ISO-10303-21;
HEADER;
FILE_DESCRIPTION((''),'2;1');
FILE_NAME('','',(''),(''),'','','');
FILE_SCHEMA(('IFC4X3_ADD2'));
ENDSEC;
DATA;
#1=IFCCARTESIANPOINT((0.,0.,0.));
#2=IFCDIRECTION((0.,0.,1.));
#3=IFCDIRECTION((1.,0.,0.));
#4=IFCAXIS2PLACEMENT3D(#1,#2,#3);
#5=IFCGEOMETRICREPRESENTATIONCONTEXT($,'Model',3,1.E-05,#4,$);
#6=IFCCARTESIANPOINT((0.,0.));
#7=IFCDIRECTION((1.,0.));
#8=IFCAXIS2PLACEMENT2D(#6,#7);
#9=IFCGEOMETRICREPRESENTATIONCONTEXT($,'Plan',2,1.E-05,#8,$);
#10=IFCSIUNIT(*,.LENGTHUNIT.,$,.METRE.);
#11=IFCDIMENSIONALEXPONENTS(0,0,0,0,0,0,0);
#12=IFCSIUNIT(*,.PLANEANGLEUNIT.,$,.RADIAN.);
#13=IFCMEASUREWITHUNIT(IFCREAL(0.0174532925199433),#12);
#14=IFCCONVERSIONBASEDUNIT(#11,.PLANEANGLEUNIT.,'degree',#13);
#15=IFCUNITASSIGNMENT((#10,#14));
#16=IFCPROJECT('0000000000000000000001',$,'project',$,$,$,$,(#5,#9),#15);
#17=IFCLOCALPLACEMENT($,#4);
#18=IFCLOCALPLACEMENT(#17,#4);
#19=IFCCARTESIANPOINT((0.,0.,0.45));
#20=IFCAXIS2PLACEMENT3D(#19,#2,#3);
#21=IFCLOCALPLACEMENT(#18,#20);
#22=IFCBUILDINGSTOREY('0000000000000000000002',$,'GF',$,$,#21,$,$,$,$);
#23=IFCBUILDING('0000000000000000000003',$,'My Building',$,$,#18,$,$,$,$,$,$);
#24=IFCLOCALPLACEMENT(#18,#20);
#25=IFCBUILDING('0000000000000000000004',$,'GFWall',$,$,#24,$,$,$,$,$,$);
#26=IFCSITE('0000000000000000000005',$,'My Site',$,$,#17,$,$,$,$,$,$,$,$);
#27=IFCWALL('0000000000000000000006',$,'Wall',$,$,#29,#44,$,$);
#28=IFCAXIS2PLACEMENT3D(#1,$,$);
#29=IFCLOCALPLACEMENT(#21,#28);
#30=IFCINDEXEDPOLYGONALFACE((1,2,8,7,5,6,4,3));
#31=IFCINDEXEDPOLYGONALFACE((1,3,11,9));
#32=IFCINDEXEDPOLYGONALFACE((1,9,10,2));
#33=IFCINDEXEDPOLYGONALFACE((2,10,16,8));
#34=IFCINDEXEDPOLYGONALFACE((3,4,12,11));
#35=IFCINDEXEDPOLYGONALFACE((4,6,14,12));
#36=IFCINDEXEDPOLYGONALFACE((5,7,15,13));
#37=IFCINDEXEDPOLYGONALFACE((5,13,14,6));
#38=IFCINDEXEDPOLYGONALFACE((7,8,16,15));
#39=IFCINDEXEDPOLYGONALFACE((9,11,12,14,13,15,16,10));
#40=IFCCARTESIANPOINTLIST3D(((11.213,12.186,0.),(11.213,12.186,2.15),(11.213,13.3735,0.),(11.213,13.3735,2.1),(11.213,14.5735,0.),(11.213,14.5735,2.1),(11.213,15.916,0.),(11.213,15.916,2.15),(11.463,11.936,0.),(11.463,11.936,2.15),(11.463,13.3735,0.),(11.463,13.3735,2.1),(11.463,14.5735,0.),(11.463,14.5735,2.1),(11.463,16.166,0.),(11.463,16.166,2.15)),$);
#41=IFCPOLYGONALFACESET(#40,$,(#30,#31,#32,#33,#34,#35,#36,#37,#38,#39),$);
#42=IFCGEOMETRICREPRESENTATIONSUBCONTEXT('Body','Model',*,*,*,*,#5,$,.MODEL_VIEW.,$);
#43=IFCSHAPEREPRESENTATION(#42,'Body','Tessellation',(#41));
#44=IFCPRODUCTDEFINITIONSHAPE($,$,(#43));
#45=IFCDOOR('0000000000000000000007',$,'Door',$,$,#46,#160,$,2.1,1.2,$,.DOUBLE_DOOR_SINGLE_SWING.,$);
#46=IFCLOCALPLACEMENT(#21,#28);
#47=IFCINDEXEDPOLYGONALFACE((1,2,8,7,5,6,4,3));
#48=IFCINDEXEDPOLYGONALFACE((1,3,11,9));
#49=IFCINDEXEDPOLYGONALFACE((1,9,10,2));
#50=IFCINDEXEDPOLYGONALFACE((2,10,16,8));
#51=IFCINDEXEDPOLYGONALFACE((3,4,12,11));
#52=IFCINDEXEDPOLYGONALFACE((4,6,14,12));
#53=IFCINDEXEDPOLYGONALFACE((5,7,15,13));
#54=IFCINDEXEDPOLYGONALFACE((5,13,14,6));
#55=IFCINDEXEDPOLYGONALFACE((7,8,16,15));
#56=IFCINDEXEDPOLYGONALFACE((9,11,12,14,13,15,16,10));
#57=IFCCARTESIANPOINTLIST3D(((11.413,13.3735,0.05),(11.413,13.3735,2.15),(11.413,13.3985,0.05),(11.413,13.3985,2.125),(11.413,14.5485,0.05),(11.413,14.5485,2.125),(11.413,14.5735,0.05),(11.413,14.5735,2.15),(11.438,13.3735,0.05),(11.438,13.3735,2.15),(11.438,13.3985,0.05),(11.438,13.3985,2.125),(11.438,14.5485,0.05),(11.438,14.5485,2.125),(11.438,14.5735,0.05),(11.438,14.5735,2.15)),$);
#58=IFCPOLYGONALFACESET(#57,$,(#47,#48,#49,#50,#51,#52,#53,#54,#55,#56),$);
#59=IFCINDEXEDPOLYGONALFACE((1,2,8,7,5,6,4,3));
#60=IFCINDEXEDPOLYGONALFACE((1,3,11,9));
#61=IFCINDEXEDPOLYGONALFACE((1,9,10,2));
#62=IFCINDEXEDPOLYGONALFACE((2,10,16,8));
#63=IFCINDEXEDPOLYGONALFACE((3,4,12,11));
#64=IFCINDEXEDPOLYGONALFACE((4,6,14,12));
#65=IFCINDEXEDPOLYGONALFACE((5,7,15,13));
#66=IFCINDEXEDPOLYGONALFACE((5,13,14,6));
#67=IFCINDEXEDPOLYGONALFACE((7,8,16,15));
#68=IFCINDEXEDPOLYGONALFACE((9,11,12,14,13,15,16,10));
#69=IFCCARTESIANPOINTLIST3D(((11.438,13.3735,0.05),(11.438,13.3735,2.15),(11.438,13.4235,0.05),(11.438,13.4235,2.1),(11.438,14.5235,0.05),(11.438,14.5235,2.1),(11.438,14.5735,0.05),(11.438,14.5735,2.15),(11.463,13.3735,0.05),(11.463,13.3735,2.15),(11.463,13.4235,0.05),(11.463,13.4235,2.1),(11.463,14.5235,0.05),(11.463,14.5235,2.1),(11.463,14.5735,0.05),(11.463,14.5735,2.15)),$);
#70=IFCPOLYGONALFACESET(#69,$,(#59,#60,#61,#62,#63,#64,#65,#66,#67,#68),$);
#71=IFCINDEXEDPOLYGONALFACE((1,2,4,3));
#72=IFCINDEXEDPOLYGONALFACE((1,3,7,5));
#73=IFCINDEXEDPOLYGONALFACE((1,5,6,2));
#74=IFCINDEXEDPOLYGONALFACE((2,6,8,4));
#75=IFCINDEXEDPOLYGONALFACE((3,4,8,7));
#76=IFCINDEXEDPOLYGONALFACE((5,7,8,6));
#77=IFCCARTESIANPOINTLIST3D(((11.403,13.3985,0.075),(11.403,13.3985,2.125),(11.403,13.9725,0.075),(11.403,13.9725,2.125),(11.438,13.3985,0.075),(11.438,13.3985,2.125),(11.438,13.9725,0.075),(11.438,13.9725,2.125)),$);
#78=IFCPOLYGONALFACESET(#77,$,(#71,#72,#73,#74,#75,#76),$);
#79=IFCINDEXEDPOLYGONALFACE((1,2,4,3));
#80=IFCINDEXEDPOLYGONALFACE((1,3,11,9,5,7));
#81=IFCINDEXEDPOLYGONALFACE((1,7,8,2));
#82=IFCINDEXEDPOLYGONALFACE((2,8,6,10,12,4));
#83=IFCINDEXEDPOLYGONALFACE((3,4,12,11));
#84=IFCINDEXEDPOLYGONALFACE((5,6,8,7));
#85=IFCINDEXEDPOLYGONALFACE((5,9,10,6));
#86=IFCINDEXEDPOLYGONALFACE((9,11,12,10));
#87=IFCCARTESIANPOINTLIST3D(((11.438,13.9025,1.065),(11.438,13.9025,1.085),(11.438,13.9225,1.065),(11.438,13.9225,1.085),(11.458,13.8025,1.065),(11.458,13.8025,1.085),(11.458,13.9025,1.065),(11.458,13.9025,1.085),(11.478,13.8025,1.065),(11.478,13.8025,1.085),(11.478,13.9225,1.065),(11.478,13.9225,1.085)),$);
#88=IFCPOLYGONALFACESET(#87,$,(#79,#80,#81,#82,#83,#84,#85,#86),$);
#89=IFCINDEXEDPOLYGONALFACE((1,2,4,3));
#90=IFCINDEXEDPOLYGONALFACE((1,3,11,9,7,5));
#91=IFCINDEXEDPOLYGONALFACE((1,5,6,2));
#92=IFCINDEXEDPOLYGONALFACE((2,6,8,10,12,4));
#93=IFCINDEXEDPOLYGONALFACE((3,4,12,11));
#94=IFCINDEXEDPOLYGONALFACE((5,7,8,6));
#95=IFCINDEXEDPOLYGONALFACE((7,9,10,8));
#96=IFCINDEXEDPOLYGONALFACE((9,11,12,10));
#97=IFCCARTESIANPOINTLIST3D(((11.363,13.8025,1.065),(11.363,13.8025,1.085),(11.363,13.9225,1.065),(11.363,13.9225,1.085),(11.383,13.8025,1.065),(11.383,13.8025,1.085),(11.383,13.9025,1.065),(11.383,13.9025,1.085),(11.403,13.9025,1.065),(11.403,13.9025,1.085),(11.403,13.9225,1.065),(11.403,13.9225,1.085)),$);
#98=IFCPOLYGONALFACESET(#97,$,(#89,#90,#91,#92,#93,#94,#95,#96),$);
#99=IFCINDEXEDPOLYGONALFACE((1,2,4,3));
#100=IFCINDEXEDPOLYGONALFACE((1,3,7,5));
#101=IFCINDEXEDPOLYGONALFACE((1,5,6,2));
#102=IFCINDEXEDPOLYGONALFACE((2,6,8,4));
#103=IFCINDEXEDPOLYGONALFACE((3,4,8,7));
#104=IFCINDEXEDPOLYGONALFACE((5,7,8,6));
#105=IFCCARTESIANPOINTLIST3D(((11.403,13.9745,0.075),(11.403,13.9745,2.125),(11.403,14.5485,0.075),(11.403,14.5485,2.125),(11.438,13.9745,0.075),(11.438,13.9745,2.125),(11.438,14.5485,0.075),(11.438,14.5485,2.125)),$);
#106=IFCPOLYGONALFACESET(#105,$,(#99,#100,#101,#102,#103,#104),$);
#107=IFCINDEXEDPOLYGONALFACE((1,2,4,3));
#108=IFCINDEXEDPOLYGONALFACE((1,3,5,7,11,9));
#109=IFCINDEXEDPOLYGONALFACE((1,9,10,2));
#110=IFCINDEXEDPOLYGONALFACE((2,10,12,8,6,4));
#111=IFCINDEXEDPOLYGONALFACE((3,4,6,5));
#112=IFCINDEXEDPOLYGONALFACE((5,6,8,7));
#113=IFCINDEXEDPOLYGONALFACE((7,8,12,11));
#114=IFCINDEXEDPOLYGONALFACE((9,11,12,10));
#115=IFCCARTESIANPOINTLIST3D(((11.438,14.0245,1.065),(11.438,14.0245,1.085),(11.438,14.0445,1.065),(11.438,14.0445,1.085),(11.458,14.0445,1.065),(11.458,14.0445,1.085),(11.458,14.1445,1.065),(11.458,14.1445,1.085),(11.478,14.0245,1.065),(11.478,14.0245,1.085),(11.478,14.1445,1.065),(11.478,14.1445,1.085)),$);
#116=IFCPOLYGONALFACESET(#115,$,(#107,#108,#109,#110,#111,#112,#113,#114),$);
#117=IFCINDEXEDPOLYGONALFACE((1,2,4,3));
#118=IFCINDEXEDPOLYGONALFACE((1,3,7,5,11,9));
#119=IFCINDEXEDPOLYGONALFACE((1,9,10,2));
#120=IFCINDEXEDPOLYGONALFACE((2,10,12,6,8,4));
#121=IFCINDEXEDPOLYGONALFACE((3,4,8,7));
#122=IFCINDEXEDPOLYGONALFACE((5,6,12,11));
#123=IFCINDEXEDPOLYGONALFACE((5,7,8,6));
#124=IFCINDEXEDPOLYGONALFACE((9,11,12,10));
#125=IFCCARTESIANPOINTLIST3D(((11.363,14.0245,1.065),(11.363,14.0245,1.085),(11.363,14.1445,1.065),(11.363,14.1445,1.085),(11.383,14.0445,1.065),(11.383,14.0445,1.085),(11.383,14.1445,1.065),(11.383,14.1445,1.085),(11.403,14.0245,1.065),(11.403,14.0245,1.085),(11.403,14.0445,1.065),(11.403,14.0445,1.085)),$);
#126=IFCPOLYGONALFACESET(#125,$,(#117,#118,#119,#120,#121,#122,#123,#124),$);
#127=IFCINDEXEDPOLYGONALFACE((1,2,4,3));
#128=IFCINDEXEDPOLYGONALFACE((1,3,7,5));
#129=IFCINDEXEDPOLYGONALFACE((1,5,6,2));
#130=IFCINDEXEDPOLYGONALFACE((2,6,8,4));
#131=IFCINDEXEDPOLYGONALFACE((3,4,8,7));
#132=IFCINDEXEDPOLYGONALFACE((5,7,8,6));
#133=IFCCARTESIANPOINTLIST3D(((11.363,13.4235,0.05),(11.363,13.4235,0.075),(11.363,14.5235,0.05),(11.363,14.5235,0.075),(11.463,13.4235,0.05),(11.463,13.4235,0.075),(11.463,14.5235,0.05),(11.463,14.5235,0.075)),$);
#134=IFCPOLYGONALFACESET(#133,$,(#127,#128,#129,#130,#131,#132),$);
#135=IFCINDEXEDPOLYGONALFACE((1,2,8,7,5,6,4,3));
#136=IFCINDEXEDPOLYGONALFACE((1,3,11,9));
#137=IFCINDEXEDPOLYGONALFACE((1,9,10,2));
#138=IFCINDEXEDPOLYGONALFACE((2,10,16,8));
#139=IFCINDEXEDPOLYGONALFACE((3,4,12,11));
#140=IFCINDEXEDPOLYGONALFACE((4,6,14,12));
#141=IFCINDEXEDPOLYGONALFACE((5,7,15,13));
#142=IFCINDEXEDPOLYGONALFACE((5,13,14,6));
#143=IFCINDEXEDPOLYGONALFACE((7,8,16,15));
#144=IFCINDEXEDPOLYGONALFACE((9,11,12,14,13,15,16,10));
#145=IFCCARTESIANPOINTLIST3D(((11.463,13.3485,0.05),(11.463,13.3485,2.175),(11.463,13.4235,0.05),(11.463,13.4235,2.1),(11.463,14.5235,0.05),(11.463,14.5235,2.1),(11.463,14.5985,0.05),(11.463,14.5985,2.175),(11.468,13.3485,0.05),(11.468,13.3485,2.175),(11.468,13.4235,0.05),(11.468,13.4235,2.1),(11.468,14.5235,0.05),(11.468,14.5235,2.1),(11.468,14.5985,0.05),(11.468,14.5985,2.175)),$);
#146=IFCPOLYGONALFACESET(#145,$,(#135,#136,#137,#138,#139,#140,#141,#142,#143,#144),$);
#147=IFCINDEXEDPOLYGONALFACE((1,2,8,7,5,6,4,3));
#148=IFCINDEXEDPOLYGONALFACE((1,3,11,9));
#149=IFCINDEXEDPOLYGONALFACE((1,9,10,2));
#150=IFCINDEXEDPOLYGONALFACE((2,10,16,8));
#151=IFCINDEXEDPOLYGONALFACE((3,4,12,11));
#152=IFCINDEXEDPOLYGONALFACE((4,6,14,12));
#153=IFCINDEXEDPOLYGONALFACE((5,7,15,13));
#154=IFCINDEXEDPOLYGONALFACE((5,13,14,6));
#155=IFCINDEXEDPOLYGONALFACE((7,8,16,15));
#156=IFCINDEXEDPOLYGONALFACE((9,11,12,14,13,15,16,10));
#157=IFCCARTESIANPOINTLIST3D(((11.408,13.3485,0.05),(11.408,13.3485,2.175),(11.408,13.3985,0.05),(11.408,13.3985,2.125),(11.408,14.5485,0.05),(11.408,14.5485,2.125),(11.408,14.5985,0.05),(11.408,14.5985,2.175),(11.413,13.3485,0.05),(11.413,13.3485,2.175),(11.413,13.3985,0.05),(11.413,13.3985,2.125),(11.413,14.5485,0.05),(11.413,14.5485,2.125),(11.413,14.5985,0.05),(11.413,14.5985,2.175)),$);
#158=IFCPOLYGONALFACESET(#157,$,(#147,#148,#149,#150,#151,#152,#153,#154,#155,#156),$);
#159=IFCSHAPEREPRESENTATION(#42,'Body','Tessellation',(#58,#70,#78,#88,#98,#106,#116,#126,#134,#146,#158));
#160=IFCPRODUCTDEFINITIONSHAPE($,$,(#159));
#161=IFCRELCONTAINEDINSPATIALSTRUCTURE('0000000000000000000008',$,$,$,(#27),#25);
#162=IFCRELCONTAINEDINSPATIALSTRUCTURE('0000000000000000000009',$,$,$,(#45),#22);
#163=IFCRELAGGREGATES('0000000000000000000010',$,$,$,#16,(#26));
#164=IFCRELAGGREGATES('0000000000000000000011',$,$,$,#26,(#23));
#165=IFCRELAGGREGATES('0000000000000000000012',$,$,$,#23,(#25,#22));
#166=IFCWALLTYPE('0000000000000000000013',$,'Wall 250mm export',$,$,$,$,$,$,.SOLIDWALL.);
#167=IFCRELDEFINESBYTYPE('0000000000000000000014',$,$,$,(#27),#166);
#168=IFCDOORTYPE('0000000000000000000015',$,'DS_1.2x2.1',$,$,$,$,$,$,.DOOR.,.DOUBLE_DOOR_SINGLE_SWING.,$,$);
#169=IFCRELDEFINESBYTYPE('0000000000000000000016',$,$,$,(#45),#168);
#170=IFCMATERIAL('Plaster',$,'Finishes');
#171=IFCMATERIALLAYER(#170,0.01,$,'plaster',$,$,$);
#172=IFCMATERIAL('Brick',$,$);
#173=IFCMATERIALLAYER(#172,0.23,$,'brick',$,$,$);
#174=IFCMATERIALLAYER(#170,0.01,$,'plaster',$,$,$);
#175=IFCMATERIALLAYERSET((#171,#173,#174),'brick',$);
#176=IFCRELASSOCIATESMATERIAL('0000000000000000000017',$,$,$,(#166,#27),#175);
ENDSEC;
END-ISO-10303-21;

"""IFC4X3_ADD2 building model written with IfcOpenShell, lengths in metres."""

from ifc_helpers import new_model, entity, si_unit, converted_unit, frame, origin_with_axes, origin_2d_with_axis, place, context, subcontext, project, spatial, line, indexed_curve, outline, extrude, shape, source, transform, mapped, material, layer, layer_set, layer_usage, type_object, type_shapes, element, fill, save


model = new_model("IFC4X3_ADD2")

# Units and contexts
model_context = context("Model", 3, precision=1e-05, world=origin_with_axes())
plan_context = context("Plan", 2, precision=1e-05, world=origin_2d_with_axis())
body_context_1 = subcontext(model_context, "Body", "Model", "MODEL_VIEW")
body_context_2 = subcontext(plan_context, "Body", "Plan", "PLAN_VIEW")
ifc_project = project(units=[si_unit("LENGTHUNIT", "METRE"), converted_unit("PLANEANGLEUNIT", "degree", entity("IfcReal", 0.0174532925199433), si_unit("PLANEANGLEUNIT", "RADIAN"), dimensions=[0, 0, 0, 0, 0, 0, 0])], contexts=[model_context, plan_context])

# Site, buildings
site_placement = place(None, origin_with_axes())
site = spatial("IfcSite", under=ifc_project, at=site_placement, Name="My Site")
building_1_placement = place(site_placement, origin_with_axes())
building_1 = spatial("IfcBuilding", under=site, at=building_1_placement, Name="My Building")
building_2_placement = place(building_1_placement, frame((0.0, 0.0, 0.45), z_axis=(0.0, 0.0, 1.0), x_axis=(1.0, 0.0, 0.0)))
building_2 = spatial("IfcBuilding", under=building_1, at=building_2_placement, Name="GFWall")

# Shared definitions
ifc_material_1 = material(Name="Plaster", Category="Finishes")

# Shared definitions
storey_placement = place(building_1_placement, frame((0.0, 0.0, 0.45), z_axis=(0.0, 0.0, 1.0), x_axis=(1.0, 0.0, 0.0)))
storey = spatial("IfcBuildingStorey", under=building_1, at=storey_placement, Name="GF")

# Shared definitions
ifc_layer_1 = layer(ifc_material_1, 0.01, Name="plaster")
ifc_material_2 = material(Name="Brick")
ifc_layer_2 = layer(ifc_material_2, 0.23, Name="brick")
ifc_layer_3 = layer(ifc_material_1, 0.01, Name="plaster")
ifc_layer_set_1 = layer_set([ifc_layer_1, ifc_layer_2, ifc_layer_3], Name="brick")
wall_type_1 = type_object("IfcWallType", Name="Wall 250mm export", PredefinedType="SOLIDWALL", material=ifc_layer_set_1)

# Wall, opening, door
ifc_layer_usage_1 = layer_usage(ifc_layer_set_1, "AXIS2", "POSITIVE", 0.0)
wall_1_placement = place(building_2_placement, frame((11.463, 11.936, 0.0), z_axis=(0.0, 0.0, 1.0), x_axis=(0.0, 1.0, 0.0)))
wall_1 = element("IfcWall", 1, at=wall_1_placement, inside=building_2, type_object=wall_type_1, material=ifc_layer_usage_1, Name="Wall", context=body_context_1, shape_type="SweptSolid", body=[
    extrude(outline(indexed_curve([(0.0, 0.0), (0.25, 0.25), (3.98, 0.25), (4.23, 0.0)], segments=[line(1, 2, 3, 4, 1)])), origin_with_axes(), (0.0, 0.0, 1.0), 2.15),
])
shared_shape_1 = source(origin_with_axes(), body_context_1, "Body", "SweptSolid", [
    extrude(outline(indexed_curve([(0.0, 0.0), (1.2, 0.0), (1.2, 2.1), (0.0, 2.1)], segments=[line(1, 2, 3, 4, 1)])), frame((0.0, -0.6, 0.0), z_axis=(0.0, -1.0, 0.0), x_axis=(1.0, 0.0, 0.0)), (0.0, 0.0, -1.0), 1.2),
])
opening_1_placement = place(wall_1_placement, frame((1.4375, 0.0, 0.0), z_axis=(0.0, 0.0, 1.0), x_axis=(1.0, 0.0, 0.0)))
opening_1 = element("IfcOpeningElement", 2, at=opening_1_placement, cuts=wall_1, PredefinedType="OPENING", context=body_context_1, shape_type="MappedRepresentation", body=[
    mapped(shared_shape_1, transform((0.0, 0.0, 0.0), x_axis=(1.0, 0.0, 0.0), y_axis=(0.0, 1.0, 0.0), z_axis=(0.0, 0.0, 1.0), scale=1.0)),
])
door_type_1 = type_object("IfcDoorType", Name="DS_1.2x2.1", OperationType="DOUBLE_DOOR_SINGLE_SWING", PredefinedType="DOOR")
shared_shape_2 = source(origin_with_axes(), body_context_1, "Body", "SweptSolid", [
    extrude(outline(indexed_curve([(0.0, 0.0), (0.0, 2.1), (1.2, 2.1), (1.2, 0.0), (1.175, 0.0), (1.175, 2.075), (0.025, 2.075), (0.025, 0.0)], segments=[line(1, 2, 3, 4, 5, 6, 7, 8, 1)])), frame((0.0, 0.025, 0.0), z_axis=(0.0, -1.0, 0.0), x_axis=(1.0, 0.0, 0.0)), (0.0, 0.0, -1.0), 0.025),
    extrude(outline(indexed_curve([(0.0, 0.0), (0.0, 2.1), (1.2, 2.1), (1.2, 0.0), (1.15, 0.0), (1.15, 2.05), (0.05, 2.05), (0.05, 0.0)], segments=[line(1, 2, 3, 4, 5, 6, 7, 8, 1)])), frame((0.0, 0.0, 0.0), z_axis=(0.0, -1.0, 0.0), x_axis=(1.0, 0.0, 0.0)), (0.0, 0.0, -1.0), 0.025),
    extrude(outline(indexed_curve([(0.0, 0.0), (0.574, 0.0), (0.574, 0.035), (0.0, 0.035)], segments=[line(1, 2, 3, 4, 1)])), frame((0.025, 0.025, 0.025), z_axis=(0.0, 0.0, 1.0), x_axis=(1.0, 0.0, 0.0)), (0.0, 0.0, 1.0), 2.05),
    extrude(outline(indexed_curve([(0.0, 0.0), (0.0, -0.04), (-0.12, -0.04), (-0.12, -0.02), (-0.02, -0.02), (-0.02, 0.0)], segments=[line(1, 2, 3, 4, 5, 6, 1)])), frame((0.549, 0.025, 1.015), z_axis=(0.0, 0.0, 1.0), x_axis=(1.0, 0.0, 0.0)), (0.0, 0.0, 1.0), 0.02),
    extrude(outline(indexed_curve([(0.0, 0.0), (0.0, 0.04), (-0.12, 0.04), (-0.12, 0.02), (-0.02, 0.02), (-0.02, 0.0)], segments=[line(1, 2, 3, 4, 5, 6, 1)])), frame((0.549, 0.06, 1.015), z_axis=(0.0, 0.0, 1.0), x_axis=(1.0, 0.0, 0.0)), (0.0, 0.0, 1.0), 0.02),
    extrude(outline(indexed_curve([(0.0, 0.0), (-0.574, 0.0), (-0.574, 0.035), (0.0, 0.035)], segments=[line(1, 2, 3, 4, 1)])), frame((1.175, 0.025, 0.025), z_axis=(0.0, 0.0, 1.0), x_axis=(1.0, 0.0, 0.0)), (0.0, 0.0, 1.0), 2.05),
    extrude(outline(indexed_curve([(0.0, 0.0), (0.0, -0.04), (0.12, -0.04), (0.12, -0.02), (0.02, -0.02), (0.02, 0.0)], segments=[line(1, 2, 3, 4, 5, 6, 1)])), frame((0.651, 0.025, 1.015), z_axis=(0.0, 0.0, 1.0), x_axis=(1.0, 0.0, 0.0)), (0.0, 0.0, 1.0), 0.02),
    extrude(outline(indexed_curve([(0.0, 0.0), (0.0, 0.04), (0.12, 0.04), (0.12, 0.02), (0.02, 0.02), (0.02, 0.0)], segments=[line(1, 2, 3, 4, 5, 6, 1)])), frame((0.651, 0.06, 1.015), z_axis=(0.0, 0.0, 1.0), x_axis=(1.0, 0.0, 0.0)), (0.0, 0.0, 1.0), 0.02),
    extrude(outline(indexed_curve([(0.0, 0.0), (1.1, 0.0), (1.1, 0.1), (0.0, 0.1)], segments=[line(1, 2, 3, 4, 1)])), frame((0.05, 0.0, 0.0), z_axis=(0.0, 0.0, 1.0), x_axis=(1.0, 0.0, 0.0)), (0.0, 0.0, 1.0), 0.025),
    extrude(outline(indexed_curve([(0.0, 0.0), (0.0, 2.125), (1.25, 2.125), (1.25, 0.0), (1.175, 0.0), (1.175, 2.05), (0.075, 2.05), (0.075, 0.0)], segments=[line(1, 2, 3, 4, 5, 6, 7, 8, 1)])), frame((-0.025, -0.005, 0.0), z_axis=(0.0, -1.0, 0.0), x_axis=(1.0, 0.0, 0.0)), (0.0, 0.0, -1.0), 0.005),
    extrude(outline(indexed_curve([(0.0, 0.0), (0.0, 2.125), (1.25, 2.125), (1.25, 0.0), (1.2, 0.0), (1.2, 2.075), (0.05, 2.075), (0.05, 0.0)], segments=[line(1, 2, 3, 4, 5, 6, 7, 8, 1)])), frame((-0.025, 0.05, 0.0), z_axis=(0.0, -1.0, 0.0), x_axis=(1.0, 0.0, 0.0)), (0.0, 0.0, -1.0), 0.005),
])
shared_shape_3 = source(origin_with_axes(), body_context_2, "Body", "Curve2D", [
    entity("IfcIndexedPolyCurve", entity("IfcCartesianPointList2D", [[0.0, 0.0], [0.0, 0.05], [0.025, 0.05], [0.025, 0.025], [0.05, 0.025], [0.05, 0.0]]), [entity("IfcLineIndex", [1, 2, 3, 4, 5, 6, 1])]),
    entity("IfcIndexedPolyCurve", entity("IfcCartesianPointList2D", [[1.2, 0.0], [1.2, 0.05], [1.175, 0.05], [1.175, 0.025], [1.15, 0.025], [1.15, 0.0]]), [entity("IfcLineIndex", [1, 2, 3, 4, 5, 6, 1])]),
    entity("IfcTrimmedCurve", entity("IfcEllipse", entity("IfcAxis2Placement2D", entity("IfcCartesianPoint", [0.06, 0.05]), entity("IfcDirection", [1.0, 0.0])), 0.54, 0.575), [entity("IfcCartesianPoint", [0.6, 0.05])], [entity("IfcCartesianPoint", [0.06, 0.625])], True, "CARTESIAN"),
    entity("IfcIndexedPolyCurve", entity("IfcCartesianPointList2D", [[0.025, 0.05], [0.06, 0.05], [0.06, 0.625], [0.025, 0.625]]), [entity("IfcLineIndex", [1, 2, 3, 4, 1])]),
    entity("IfcTrimmedCurve", entity("IfcEllipse", entity("IfcAxis2Placement2D", entity("IfcCartesianPoint", [1.14, 0.05]), entity("IfcDirection", [1.0, 0.0])), 0.54, 0.575), [entity("IfcCartesianPoint", [1.14, 0.625])], [entity("IfcCartesianPoint", [0.6, 0.05])], True, "CARTESIAN"),
    entity("IfcIndexedPolyCurve", entity("IfcCartesianPointList2D", [[1.175, 0.05], [1.14, 0.05], [1.14, 0.625], [1.175, 0.625]]), [entity("IfcLineIndex", [1, 2, 3, 4, 1])]),
])
type_shapes(door_type_1, [shared_shape_2, shared_shape_3])
door_1_placement = place(opening_1_placement, frame((0.0, 0.0, 0.05), z_axis=(0.0, 0.0, 1.0), x_axis=(1.0, 0.0, 0.0)))
door_1 = element("IfcDoor", 3, at=door_1_placement, inside=storey, type_object=door_type_1, Name="Door", OperationType="DOUBLE_DOOR_SINGLE_SWING", OverallHeight=2.1, OverallWidth=1.2, shapes=[
    shape(body_context_1, "Body", "MappedRepresentation", [mapped(shared_shape_2, transform((0.0, 0.0, 0.0), x_axis=(1.0, 0.0, 0.0), y_axis=(0.0, 1.0, 0.0), z_axis=(0.0, 0.0, 1.0), scale=1.0))]),
    shape(body_context_2, "Body", "MappedRepresentation", [mapped(shared_shape_3, transform((0.0, 0.0, 0.0), x_axis=(1.0, 0.0, 0.0), y_axis=(0.0, 1.0, 0.0), z_axis=(0.0, 0.0, 1.0), scale=1.0))]),
])
fill(opening_1, door_1)

save(model, "model.ifc")
